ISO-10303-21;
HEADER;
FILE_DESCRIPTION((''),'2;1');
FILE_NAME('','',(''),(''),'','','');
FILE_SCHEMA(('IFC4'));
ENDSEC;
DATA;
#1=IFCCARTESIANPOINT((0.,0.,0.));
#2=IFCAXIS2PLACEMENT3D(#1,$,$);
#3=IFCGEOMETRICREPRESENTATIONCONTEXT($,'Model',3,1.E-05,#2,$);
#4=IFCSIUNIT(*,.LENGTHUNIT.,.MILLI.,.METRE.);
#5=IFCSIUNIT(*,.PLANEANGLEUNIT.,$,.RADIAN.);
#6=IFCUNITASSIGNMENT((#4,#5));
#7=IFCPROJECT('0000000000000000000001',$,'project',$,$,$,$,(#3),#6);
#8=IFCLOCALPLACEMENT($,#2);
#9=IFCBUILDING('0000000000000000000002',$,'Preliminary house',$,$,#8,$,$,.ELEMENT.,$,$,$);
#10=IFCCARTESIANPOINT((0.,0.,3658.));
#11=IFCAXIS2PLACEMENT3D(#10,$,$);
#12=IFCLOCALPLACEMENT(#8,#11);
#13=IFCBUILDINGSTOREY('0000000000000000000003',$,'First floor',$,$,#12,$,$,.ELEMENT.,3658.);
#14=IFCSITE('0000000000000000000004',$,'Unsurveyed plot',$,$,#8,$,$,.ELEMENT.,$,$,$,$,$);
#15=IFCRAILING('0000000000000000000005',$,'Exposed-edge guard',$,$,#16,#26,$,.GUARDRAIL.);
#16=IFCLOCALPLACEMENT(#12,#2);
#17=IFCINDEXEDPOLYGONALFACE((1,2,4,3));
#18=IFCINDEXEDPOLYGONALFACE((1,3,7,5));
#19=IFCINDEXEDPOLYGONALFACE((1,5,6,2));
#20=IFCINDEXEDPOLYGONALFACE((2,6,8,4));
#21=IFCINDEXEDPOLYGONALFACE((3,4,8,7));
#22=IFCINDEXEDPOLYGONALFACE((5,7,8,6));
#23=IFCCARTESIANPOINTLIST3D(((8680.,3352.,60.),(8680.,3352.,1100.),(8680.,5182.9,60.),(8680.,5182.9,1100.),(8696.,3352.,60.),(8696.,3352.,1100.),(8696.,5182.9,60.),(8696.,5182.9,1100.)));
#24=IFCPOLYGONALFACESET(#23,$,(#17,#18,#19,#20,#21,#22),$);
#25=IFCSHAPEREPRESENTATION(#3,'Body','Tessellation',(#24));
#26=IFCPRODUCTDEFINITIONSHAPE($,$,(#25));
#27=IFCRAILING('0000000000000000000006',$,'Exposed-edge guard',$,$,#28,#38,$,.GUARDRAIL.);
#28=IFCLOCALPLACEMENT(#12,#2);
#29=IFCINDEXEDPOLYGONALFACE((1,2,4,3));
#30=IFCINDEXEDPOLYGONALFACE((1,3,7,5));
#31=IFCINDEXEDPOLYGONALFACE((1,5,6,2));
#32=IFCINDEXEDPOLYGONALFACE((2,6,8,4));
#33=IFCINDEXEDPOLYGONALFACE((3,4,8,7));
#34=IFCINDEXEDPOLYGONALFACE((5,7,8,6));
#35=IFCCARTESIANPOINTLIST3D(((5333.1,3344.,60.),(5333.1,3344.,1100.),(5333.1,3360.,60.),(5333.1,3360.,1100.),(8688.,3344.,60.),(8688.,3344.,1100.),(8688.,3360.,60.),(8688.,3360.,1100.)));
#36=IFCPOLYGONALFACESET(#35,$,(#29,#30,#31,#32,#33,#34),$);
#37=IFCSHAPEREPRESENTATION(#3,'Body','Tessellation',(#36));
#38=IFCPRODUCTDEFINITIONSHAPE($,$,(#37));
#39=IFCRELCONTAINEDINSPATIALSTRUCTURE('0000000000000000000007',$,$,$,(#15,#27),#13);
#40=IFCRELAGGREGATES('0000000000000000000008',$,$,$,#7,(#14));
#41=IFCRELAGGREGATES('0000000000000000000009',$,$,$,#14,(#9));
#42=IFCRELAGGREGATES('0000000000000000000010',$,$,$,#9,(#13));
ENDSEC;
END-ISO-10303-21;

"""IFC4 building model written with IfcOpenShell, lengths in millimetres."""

from ifc_helpers import new_model, si_unit, frame, origin, place, context, project, spatial, polyline, outline, extrude, element, save


model = new_model("IFC4")

# Units and contexts
model_context = context("Model", 3, precision=1e-05, world=origin())
ifc_project = project(units=[si_unit("LENGTHUNIT", "METRE", prefix="MILLI"), si_unit("PLANEANGLEUNIT", "RADIAN")], contexts=[model_context])

# Site, building, storey
placement_1 = place(None, origin())
site = spatial("IfcSite", under=ifc_project, at=placement_1, Name="Unsurveyed plot", CompositionType="ELEMENT")
building = spatial("IfcBuilding", under=site, at=placement_1, Name="Preliminary house", CompositionType="ELEMENT")
placement_2 = place(placement_1, frame((0.0, 0.0, 3658.0)))
storey = spatial("IfcBuildingStorey", under=building, at=placement_2, Name="First floor", CompositionType="ELEMENT", Elevation=3658.0)

# Railings
element("IfcRailing", 1, at=placement_2, inside=storey, Name="Exposed-edge guard", PredefinedType="GUARDRAIL", context=model_context, shape_type="SweptSolid", body=[
    extrude(outline(polyline([(8680.0, 5182.9), (8696.0, 5182.9), (8696.0, 3352.0), (8680.0, 3352.0), (8680.0, 5182.9)])), frame((0.0, 0.0, 60.0)), (0.0, 0.0, 1.0), 1040.0),
])
element("IfcRailing", 2, at=placement_2, inside=storey, Name="Exposed-edge guard", PredefinedType="GUARDRAIL", context=model_context, shape_type="SweptSolid", body=[
    extrude(outline(polyline([(8688.0, 3360.0), (8688.0, 3344.0), (5333.1, 3344.0), (5333.1, 3360.0), (8688.0, 3360.0)])), frame((0.0, 0.0, 60.0)), (0.0, 0.0, 1.0), 1040.0),
])

save(model, "model.ifc")
